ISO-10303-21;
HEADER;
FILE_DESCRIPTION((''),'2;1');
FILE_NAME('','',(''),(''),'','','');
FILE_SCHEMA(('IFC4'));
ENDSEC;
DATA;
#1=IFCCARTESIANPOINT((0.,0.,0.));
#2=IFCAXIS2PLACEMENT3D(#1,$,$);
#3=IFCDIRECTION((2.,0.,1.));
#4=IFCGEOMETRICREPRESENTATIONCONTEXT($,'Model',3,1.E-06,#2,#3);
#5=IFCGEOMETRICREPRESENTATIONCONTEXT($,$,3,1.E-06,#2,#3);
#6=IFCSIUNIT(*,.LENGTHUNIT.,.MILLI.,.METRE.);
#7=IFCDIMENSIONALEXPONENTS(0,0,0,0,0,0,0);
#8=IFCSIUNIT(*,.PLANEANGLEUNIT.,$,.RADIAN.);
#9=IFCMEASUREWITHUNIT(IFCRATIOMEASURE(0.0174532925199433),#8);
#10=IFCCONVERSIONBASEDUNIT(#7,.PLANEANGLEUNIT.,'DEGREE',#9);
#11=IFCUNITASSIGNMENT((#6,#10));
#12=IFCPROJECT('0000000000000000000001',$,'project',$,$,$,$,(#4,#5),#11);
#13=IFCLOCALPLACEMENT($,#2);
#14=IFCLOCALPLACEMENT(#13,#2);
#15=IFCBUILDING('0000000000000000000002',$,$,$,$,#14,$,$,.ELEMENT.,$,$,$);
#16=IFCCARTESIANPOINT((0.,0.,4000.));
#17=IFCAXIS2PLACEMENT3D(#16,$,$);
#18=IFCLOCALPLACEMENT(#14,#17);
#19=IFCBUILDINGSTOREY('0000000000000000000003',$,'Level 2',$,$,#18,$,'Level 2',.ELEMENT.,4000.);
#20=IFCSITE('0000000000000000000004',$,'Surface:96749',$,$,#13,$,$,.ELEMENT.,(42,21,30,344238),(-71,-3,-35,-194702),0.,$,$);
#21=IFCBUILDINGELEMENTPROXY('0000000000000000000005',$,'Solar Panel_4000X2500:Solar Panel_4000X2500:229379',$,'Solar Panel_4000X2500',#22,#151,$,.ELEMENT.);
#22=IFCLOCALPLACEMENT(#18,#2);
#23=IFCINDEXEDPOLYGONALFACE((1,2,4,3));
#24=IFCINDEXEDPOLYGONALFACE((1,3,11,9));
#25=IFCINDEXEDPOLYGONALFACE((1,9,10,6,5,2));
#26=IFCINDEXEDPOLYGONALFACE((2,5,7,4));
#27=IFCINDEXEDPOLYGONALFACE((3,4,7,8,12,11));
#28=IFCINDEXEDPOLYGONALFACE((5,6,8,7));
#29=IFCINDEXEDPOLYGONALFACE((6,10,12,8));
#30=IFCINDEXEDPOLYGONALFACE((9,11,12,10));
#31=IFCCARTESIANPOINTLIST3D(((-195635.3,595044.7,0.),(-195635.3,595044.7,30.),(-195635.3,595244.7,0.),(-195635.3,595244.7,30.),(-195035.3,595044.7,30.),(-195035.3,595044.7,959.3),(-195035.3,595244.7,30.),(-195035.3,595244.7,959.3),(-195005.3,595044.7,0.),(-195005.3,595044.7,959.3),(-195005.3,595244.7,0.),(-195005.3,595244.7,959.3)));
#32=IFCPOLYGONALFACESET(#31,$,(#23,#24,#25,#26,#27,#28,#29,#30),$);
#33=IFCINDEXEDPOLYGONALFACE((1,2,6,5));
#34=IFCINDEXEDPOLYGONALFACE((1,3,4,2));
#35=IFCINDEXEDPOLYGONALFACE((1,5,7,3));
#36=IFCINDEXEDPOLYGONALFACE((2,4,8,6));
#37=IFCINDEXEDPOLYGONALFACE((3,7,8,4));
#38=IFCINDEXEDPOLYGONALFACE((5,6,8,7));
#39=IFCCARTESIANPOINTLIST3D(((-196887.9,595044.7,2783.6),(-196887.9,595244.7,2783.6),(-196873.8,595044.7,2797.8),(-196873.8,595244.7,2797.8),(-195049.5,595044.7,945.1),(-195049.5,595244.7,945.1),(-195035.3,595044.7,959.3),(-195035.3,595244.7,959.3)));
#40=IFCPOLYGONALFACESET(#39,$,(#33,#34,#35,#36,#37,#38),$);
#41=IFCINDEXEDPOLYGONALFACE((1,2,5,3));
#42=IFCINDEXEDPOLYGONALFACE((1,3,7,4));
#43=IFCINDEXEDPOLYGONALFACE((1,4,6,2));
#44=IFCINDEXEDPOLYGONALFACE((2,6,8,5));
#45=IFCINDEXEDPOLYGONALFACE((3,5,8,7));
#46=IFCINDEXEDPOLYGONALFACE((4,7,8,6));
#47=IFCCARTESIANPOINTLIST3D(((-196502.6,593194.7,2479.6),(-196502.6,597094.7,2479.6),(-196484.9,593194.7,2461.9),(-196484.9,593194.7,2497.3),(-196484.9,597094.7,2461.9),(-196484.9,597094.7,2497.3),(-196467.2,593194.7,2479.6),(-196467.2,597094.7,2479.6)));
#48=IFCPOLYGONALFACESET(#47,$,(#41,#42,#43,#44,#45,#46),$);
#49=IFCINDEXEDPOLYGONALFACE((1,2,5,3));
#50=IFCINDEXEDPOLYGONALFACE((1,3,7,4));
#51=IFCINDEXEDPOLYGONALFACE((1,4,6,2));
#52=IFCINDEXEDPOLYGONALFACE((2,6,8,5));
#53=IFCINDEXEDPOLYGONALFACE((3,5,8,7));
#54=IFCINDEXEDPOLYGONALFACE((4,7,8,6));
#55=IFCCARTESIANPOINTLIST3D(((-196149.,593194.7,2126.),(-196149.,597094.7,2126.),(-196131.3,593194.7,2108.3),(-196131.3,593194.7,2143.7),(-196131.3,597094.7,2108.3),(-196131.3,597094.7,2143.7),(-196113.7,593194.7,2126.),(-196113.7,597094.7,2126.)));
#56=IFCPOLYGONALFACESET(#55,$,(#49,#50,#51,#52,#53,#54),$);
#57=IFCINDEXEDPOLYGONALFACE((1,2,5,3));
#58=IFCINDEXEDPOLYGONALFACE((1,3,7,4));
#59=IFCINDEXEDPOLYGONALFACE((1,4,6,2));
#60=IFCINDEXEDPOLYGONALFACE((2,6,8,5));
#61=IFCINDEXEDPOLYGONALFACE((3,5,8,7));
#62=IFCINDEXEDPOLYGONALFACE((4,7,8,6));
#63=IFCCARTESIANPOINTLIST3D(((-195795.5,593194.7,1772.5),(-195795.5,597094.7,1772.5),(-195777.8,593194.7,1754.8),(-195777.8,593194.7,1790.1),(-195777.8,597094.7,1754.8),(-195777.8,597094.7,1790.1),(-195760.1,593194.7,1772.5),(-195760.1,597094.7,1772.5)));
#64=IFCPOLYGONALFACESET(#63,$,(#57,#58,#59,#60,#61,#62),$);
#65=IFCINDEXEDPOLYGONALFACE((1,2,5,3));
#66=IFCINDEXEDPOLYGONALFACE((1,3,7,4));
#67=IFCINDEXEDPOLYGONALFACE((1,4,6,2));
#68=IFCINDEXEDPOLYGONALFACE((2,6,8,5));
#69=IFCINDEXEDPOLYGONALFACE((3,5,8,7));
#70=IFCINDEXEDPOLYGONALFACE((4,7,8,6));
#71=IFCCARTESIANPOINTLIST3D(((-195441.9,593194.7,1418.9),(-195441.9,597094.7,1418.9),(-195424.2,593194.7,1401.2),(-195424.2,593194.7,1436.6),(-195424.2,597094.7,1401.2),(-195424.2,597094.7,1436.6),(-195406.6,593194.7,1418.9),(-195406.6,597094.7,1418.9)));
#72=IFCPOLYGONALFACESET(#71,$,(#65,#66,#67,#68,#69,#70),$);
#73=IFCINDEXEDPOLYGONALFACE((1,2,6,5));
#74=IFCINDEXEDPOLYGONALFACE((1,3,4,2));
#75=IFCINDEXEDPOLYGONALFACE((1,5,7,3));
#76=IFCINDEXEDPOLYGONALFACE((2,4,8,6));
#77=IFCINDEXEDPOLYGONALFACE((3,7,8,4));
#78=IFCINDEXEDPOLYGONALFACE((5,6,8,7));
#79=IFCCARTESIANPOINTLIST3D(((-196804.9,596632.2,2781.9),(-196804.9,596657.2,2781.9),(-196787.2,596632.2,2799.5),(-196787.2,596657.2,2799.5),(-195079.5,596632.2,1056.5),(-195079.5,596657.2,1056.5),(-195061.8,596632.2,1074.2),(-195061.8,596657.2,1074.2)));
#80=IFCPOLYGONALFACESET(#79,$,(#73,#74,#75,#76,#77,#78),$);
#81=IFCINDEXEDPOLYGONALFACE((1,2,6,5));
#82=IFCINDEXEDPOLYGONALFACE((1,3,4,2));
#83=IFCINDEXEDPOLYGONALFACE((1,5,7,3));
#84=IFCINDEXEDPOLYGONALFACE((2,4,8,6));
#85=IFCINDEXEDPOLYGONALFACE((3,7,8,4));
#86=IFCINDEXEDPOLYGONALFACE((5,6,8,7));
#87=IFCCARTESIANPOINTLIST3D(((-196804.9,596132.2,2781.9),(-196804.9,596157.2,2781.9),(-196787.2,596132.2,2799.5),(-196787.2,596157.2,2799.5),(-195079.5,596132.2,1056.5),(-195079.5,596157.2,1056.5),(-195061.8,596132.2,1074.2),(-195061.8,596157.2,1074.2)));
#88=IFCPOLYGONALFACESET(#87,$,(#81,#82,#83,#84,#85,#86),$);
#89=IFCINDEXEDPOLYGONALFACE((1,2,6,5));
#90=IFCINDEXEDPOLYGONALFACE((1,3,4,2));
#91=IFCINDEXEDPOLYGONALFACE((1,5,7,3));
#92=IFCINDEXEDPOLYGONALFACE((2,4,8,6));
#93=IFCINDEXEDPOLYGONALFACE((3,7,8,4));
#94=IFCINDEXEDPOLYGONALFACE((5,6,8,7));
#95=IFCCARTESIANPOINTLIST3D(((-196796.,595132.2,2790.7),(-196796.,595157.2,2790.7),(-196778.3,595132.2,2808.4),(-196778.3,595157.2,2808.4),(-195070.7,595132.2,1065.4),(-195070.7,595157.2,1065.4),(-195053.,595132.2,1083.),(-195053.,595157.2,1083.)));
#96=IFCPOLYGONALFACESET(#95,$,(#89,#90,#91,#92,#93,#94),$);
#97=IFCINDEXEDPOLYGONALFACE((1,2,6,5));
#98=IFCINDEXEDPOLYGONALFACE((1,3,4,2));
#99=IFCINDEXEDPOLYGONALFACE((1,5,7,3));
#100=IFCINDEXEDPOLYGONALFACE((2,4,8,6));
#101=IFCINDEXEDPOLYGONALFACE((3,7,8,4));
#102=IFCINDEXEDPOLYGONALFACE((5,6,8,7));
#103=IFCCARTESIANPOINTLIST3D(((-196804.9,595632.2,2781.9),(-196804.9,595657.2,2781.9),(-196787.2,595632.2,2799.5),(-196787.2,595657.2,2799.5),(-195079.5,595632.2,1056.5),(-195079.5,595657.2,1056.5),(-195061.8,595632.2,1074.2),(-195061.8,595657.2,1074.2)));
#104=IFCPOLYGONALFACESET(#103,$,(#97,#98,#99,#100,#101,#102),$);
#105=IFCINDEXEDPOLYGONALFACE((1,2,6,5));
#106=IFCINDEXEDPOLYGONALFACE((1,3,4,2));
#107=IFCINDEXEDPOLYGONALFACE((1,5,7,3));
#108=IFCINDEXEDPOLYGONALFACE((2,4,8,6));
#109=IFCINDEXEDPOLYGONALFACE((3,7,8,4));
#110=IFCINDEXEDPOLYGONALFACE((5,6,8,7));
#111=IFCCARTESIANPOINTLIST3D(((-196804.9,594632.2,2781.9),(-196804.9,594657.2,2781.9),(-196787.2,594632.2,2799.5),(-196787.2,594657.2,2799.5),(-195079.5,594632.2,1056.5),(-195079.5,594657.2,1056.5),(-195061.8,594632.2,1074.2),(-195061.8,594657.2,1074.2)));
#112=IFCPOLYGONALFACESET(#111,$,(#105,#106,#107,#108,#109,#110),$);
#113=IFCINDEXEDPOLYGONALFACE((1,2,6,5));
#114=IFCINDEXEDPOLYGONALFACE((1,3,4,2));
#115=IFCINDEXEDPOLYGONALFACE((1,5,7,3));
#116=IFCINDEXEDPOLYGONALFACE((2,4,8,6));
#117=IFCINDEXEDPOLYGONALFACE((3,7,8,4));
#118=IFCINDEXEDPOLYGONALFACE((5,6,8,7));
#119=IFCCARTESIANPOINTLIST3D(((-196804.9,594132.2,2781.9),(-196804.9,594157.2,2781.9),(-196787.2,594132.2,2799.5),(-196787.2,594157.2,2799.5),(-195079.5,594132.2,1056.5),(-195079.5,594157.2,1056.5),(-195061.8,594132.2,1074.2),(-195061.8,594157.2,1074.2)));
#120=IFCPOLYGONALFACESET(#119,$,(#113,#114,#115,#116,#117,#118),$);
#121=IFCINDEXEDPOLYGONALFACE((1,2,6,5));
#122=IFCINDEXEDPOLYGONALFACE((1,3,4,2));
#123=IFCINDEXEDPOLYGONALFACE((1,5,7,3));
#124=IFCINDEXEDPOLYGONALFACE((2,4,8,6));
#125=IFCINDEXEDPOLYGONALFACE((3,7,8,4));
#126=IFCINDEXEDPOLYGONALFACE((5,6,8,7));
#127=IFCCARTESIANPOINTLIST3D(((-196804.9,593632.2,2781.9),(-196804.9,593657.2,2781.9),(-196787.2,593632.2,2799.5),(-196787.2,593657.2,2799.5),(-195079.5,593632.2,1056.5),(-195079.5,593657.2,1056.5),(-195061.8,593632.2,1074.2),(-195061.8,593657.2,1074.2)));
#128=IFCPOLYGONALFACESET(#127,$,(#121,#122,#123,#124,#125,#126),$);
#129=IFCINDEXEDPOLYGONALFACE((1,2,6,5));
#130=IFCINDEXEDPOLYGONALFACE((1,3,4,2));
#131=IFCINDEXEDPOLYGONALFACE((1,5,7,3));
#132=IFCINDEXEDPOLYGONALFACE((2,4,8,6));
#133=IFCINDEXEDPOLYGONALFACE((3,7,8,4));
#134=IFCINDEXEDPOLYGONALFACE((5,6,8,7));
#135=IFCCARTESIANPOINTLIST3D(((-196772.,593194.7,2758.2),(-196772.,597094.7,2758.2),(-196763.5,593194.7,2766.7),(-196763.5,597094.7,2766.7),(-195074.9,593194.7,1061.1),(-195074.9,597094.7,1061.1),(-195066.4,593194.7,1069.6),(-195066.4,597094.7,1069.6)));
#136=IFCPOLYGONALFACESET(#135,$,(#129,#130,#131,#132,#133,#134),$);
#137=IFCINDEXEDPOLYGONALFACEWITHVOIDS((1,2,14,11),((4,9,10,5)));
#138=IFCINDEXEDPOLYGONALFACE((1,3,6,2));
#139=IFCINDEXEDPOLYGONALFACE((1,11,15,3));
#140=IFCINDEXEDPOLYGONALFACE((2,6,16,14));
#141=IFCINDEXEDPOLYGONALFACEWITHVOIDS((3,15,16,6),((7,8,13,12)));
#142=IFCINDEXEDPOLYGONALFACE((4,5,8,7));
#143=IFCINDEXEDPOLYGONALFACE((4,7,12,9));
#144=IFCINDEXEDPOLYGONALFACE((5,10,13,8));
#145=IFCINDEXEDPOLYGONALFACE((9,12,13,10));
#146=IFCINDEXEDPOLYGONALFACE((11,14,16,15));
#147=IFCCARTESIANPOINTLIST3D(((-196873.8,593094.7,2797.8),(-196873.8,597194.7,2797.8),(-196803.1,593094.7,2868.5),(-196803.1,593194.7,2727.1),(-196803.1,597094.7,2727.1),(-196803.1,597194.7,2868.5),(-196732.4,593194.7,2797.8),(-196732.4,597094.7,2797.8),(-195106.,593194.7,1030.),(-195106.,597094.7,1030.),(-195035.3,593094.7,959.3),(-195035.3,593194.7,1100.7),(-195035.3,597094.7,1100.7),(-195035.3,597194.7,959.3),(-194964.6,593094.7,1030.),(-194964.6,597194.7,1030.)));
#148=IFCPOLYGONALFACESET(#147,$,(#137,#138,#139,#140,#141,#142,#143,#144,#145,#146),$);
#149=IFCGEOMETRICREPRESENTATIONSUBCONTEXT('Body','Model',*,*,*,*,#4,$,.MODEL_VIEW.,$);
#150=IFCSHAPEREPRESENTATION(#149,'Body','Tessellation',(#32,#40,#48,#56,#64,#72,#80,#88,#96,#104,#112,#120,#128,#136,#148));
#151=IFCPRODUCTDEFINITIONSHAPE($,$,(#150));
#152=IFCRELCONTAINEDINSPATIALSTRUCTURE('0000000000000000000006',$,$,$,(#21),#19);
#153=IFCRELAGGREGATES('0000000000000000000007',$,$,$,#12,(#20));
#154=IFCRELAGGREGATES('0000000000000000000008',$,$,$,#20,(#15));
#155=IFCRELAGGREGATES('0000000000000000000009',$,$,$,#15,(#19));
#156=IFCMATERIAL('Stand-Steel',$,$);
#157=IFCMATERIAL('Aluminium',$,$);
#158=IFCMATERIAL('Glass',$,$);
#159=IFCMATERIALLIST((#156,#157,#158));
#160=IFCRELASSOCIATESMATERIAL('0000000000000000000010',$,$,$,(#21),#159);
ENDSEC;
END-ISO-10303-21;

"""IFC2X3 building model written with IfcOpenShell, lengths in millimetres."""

from ifc_helpers import new_model, entity, si_unit, converted_unit, direction, frame, frame_2d, origin, origin_2d_with_axis, place, context, subcontext, project, spatial, polyline, rectangle, outline, extrude, source, transform, mapped, material, material_list, element, save


model = new_model("IFC2X3")

# Units and contexts
model_context = context("Model", 3, precision=1e-06, world=origin(), true_north=direction((2.0, 0.0, 1.0)))
context_of_model = context(None, 3, precision=1e-06, world=origin(), true_north=direction((2.0, 0.0, 1.0)))
body_context = subcontext(model_context, "Body", "Model", "MODEL_VIEW")
ifc_project = project(units=[si_unit("LENGTHUNIT", "METRE", prefix="MILLI"), converted_unit("PLANEANGLEUNIT", "DEGREE", entity("IfcRatioMeasure", 0.0174532925199433), si_unit("PLANEANGLEUNIT", "RADIAN"), dimensions=[0, 0, 0, 0, 0, 0, 0])], contexts=[model_context, context_of_model])

# Site, building, storey
site_placement = place(None, origin())
site = spatial("IfcSite", under=ifc_project, at=site_placement, Name="Surface:96749", CompositionType="ELEMENT", RefLatitude=(42, 21, 30, 344238), RefLongitude=(-71, -3, -35, -194702), RefElevation=0.0)
building_placement = place(site_placement, origin())
building = spatial("IfcBuilding", under=site, at=building_placement, CompositionType="ELEMENT")
storey_placement = place(building_placement, frame((0.0, 0.0, 4000.0)))
storey = spatial("IfcBuildingStorey", under=building, at=storey_placement, Name="Level 2", LongName="Level 2", CompositionType="ELEMENT", Elevation=4000.0)

# Building element proxy
ifc_material_1 = material(Name="Stand-Steel")
ifc_material_2 = material(Name="Aluminium")
ifc_material_3 = material(Name="Glass")
shared_shape = source(origin(), body_context, "Body", "SweptSolid", [
    extrude(outline(polyline([(-629.5, -220.0), (329.8, -220.0), (329.8, 410.0), (299.8, 410.0), (299.8, -190.0), (-629.5, -190.0), (-629.5, -220.0)])), frame((-190.0, -100.0, 299.8), z_axis=(0.0, 1.0, 0.0), x_axis=(0.0, 0.0, -1.0)), (0.0, 0.0, 1.0), 200.0),
    extrude(rectangle(XDim=20.0, YDim=200.0, at=frame_2d((0.0, 0.0), x_axis=(0.0, 1.0))), frame((-7.1, 0.0, 922.2), z_axis=(-0.707107, 0.0, 0.707107), x_axis=(0.0, 1.0, 0.0)), (0.0, 0.0, 1.0), 2600.0),
    extrude(rectangle(XDim=25.0, YDim=25.0, at=frame_2d((0.0, 0.0), x_axis=(1.0, 0.0))), frame((-1449.6, -1950.0, 2449.6), z_axis=(0.0, 1.0, 0.0), x_axis=(-0.707107, 0.0, -0.707107)), (0.0, 0.0, 1.0), 3900.0),
    extrude(rectangle(XDim=25.0, YDim=25.0, at=origin_2d_with_axis()), frame((-1096.0, -1950.0, 2096.0), z_axis=(0.0, 1.0, 0.0), x_axis=(-0.707107, 0.0, -0.707107)), (0.0, 0.0, 1.0), 3900.0),
    extrude(rectangle(XDim=25.0, YDim=25.0, at=origin_2d_with_axis()), frame((-742.5, -1950.0, 1742.5), z_axis=(0.0, 1.0, 0.0), x_axis=(-0.707107, 0.0, -0.707107)), (0.0, 0.0, 1.0), 3900.0),
    extrude(rectangle(XDim=25.0, YDim=25.0, at=frame_2d((0.0, 0.0), x_axis=(1.0, 0.0))), frame((-388.9, -1950.0, 1388.9), z_axis=(0.0, 1.0, 0.0), x_axis=(-0.707107, 0.0, -0.707107)), (0.0, 0.0, 1.0), 3900.0),
    extrude(rectangle(XDim=25.0, YDim=25.0, at=frame_2d((0.0, 0.0), x_axis=(0.0, 1.0))), frame((-35.4, 1500.0, 1035.4), z_axis=(-0.707107, 0.0, 0.707107), x_axis=(0.0, 1.0, 0.0)), (0.0, 0.0, 1.0), 2440.0),
    extrude(rectangle(XDim=25.0, YDim=25.0, at=frame_2d((0.0, 0.0), x_axis=(0.0, 1.0))), frame((-35.4, 1000.0, 1035.4), z_axis=(-0.707107, 0.0, 0.707107), x_axis=(0.0, 1.0, 0.0)), (0.0, 0.0, 1.0), 2440.0),
    extrude(rectangle(XDim=25.0, YDim=25.0, at=frame_2d((0.0, 0.0), x_axis=(0.0, 1.0))), frame((-26.5, 0.0, 1044.2), z_axis=(-0.707107, 0.0, 0.707107), x_axis=(0.0, -1.0, 0.0)), (0.0, 0.0, 1.0), 2440.0),
    extrude(rectangle(XDim=25.0, YDim=25.0, at=frame_2d((0.0, 0.0), x_axis=(0.0, 1.0))), frame((-35.4, 500.0, 1035.4), z_axis=(-0.707107, 0.0, 0.707107), x_axis=(0.0, 1.0, 0.0)), (0.0, 0.0, 1.0), 2440.0),
    extrude(rectangle(XDim=25.0, YDim=25.0, at=frame_2d((0.0, 0.0), x_axis=(0.0, 1.0))), frame((-35.4, -500.0, 1035.4), z_axis=(-0.707107, 0.0, 0.707107), x_axis=(0.0, 1.0, 0.0)), (0.0, 0.0, 1.0), 2440.0),
    extrude(rectangle(XDim=25.0, YDim=25.0, at=frame_2d((0.0, 0.0), x_axis=(0.0, 1.0))), frame((-35.4, -1000.0, 1035.4), z_axis=(-0.707107, 0.0, 0.707107), x_axis=(0.0, 1.0, 0.0)), (0.0, 0.0, 1.0), 2440.0),
    extrude(rectangle(XDim=25.0, YDim=25.0, at=frame_2d((0.0, 0.0), x_axis=(0.0, 1.0))), frame((-35.4, -1500.0, 1035.4), z_axis=(-0.707107, 0.0, 0.707107), x_axis=(0.0, 1.0, 0.0)), (0.0, 0.0, 1.0), 2440.0),
    extrude(rectangle(XDim=2400.0, YDim=12.0, at=frame_2d((0.0, 0.0), x_axis=(1.0, 0.0))), frame((-883.9, -1950.0, 1883.9), z_axis=(0.0, 1.0, 0.0), x_axis=(0.707107, 0.0, -0.707107)), (0.0, 0.0, 1.0), 3900.0),
    extrude(outline(polyline([(-2050.0, -1300.0), (2050.0, -1300.0), (2050.0, 1300.0), (-2050.0, 1300.0), (-2050.0, -1300.0)]), holes=[polyline([(1950.0, -1200.0), (-1950.0, -1200.0), (-1950.0, 1200.0), (1950.0, 1200.0), (1950.0, -1200.0)])]), frame((-919.2, 0.0, 1848.5), z_axis=(0.707107, 0.0, 0.707107), x_axis=(0.0, 1.0, 0.0)), (0.0, 0.0, 1.0), 100.0),
])
ifc_material_list_1 = material_list([ifc_material_1, ifc_material_2, ifc_material_3])
proxy_1_placement = place(storey_placement, frame((-195035.3, 595144.7, 30.0)))
element("IfcBuildingElementProxy", 1, at=proxy_1_placement, inside=storey, material=ifc_material_list_1, Name="Solar Panel_4000X2500:Solar Panel_4000X2500:229379", ObjectType="Solar Panel_4000X2500", CompositionType="ELEMENT", context=body_context, shape_type="MappedRepresentation", body=[
    mapped(shared_shape, transform((0.0, 0.0, 0.0), scale=1.0)),
])

save(model, "model.ifc")
